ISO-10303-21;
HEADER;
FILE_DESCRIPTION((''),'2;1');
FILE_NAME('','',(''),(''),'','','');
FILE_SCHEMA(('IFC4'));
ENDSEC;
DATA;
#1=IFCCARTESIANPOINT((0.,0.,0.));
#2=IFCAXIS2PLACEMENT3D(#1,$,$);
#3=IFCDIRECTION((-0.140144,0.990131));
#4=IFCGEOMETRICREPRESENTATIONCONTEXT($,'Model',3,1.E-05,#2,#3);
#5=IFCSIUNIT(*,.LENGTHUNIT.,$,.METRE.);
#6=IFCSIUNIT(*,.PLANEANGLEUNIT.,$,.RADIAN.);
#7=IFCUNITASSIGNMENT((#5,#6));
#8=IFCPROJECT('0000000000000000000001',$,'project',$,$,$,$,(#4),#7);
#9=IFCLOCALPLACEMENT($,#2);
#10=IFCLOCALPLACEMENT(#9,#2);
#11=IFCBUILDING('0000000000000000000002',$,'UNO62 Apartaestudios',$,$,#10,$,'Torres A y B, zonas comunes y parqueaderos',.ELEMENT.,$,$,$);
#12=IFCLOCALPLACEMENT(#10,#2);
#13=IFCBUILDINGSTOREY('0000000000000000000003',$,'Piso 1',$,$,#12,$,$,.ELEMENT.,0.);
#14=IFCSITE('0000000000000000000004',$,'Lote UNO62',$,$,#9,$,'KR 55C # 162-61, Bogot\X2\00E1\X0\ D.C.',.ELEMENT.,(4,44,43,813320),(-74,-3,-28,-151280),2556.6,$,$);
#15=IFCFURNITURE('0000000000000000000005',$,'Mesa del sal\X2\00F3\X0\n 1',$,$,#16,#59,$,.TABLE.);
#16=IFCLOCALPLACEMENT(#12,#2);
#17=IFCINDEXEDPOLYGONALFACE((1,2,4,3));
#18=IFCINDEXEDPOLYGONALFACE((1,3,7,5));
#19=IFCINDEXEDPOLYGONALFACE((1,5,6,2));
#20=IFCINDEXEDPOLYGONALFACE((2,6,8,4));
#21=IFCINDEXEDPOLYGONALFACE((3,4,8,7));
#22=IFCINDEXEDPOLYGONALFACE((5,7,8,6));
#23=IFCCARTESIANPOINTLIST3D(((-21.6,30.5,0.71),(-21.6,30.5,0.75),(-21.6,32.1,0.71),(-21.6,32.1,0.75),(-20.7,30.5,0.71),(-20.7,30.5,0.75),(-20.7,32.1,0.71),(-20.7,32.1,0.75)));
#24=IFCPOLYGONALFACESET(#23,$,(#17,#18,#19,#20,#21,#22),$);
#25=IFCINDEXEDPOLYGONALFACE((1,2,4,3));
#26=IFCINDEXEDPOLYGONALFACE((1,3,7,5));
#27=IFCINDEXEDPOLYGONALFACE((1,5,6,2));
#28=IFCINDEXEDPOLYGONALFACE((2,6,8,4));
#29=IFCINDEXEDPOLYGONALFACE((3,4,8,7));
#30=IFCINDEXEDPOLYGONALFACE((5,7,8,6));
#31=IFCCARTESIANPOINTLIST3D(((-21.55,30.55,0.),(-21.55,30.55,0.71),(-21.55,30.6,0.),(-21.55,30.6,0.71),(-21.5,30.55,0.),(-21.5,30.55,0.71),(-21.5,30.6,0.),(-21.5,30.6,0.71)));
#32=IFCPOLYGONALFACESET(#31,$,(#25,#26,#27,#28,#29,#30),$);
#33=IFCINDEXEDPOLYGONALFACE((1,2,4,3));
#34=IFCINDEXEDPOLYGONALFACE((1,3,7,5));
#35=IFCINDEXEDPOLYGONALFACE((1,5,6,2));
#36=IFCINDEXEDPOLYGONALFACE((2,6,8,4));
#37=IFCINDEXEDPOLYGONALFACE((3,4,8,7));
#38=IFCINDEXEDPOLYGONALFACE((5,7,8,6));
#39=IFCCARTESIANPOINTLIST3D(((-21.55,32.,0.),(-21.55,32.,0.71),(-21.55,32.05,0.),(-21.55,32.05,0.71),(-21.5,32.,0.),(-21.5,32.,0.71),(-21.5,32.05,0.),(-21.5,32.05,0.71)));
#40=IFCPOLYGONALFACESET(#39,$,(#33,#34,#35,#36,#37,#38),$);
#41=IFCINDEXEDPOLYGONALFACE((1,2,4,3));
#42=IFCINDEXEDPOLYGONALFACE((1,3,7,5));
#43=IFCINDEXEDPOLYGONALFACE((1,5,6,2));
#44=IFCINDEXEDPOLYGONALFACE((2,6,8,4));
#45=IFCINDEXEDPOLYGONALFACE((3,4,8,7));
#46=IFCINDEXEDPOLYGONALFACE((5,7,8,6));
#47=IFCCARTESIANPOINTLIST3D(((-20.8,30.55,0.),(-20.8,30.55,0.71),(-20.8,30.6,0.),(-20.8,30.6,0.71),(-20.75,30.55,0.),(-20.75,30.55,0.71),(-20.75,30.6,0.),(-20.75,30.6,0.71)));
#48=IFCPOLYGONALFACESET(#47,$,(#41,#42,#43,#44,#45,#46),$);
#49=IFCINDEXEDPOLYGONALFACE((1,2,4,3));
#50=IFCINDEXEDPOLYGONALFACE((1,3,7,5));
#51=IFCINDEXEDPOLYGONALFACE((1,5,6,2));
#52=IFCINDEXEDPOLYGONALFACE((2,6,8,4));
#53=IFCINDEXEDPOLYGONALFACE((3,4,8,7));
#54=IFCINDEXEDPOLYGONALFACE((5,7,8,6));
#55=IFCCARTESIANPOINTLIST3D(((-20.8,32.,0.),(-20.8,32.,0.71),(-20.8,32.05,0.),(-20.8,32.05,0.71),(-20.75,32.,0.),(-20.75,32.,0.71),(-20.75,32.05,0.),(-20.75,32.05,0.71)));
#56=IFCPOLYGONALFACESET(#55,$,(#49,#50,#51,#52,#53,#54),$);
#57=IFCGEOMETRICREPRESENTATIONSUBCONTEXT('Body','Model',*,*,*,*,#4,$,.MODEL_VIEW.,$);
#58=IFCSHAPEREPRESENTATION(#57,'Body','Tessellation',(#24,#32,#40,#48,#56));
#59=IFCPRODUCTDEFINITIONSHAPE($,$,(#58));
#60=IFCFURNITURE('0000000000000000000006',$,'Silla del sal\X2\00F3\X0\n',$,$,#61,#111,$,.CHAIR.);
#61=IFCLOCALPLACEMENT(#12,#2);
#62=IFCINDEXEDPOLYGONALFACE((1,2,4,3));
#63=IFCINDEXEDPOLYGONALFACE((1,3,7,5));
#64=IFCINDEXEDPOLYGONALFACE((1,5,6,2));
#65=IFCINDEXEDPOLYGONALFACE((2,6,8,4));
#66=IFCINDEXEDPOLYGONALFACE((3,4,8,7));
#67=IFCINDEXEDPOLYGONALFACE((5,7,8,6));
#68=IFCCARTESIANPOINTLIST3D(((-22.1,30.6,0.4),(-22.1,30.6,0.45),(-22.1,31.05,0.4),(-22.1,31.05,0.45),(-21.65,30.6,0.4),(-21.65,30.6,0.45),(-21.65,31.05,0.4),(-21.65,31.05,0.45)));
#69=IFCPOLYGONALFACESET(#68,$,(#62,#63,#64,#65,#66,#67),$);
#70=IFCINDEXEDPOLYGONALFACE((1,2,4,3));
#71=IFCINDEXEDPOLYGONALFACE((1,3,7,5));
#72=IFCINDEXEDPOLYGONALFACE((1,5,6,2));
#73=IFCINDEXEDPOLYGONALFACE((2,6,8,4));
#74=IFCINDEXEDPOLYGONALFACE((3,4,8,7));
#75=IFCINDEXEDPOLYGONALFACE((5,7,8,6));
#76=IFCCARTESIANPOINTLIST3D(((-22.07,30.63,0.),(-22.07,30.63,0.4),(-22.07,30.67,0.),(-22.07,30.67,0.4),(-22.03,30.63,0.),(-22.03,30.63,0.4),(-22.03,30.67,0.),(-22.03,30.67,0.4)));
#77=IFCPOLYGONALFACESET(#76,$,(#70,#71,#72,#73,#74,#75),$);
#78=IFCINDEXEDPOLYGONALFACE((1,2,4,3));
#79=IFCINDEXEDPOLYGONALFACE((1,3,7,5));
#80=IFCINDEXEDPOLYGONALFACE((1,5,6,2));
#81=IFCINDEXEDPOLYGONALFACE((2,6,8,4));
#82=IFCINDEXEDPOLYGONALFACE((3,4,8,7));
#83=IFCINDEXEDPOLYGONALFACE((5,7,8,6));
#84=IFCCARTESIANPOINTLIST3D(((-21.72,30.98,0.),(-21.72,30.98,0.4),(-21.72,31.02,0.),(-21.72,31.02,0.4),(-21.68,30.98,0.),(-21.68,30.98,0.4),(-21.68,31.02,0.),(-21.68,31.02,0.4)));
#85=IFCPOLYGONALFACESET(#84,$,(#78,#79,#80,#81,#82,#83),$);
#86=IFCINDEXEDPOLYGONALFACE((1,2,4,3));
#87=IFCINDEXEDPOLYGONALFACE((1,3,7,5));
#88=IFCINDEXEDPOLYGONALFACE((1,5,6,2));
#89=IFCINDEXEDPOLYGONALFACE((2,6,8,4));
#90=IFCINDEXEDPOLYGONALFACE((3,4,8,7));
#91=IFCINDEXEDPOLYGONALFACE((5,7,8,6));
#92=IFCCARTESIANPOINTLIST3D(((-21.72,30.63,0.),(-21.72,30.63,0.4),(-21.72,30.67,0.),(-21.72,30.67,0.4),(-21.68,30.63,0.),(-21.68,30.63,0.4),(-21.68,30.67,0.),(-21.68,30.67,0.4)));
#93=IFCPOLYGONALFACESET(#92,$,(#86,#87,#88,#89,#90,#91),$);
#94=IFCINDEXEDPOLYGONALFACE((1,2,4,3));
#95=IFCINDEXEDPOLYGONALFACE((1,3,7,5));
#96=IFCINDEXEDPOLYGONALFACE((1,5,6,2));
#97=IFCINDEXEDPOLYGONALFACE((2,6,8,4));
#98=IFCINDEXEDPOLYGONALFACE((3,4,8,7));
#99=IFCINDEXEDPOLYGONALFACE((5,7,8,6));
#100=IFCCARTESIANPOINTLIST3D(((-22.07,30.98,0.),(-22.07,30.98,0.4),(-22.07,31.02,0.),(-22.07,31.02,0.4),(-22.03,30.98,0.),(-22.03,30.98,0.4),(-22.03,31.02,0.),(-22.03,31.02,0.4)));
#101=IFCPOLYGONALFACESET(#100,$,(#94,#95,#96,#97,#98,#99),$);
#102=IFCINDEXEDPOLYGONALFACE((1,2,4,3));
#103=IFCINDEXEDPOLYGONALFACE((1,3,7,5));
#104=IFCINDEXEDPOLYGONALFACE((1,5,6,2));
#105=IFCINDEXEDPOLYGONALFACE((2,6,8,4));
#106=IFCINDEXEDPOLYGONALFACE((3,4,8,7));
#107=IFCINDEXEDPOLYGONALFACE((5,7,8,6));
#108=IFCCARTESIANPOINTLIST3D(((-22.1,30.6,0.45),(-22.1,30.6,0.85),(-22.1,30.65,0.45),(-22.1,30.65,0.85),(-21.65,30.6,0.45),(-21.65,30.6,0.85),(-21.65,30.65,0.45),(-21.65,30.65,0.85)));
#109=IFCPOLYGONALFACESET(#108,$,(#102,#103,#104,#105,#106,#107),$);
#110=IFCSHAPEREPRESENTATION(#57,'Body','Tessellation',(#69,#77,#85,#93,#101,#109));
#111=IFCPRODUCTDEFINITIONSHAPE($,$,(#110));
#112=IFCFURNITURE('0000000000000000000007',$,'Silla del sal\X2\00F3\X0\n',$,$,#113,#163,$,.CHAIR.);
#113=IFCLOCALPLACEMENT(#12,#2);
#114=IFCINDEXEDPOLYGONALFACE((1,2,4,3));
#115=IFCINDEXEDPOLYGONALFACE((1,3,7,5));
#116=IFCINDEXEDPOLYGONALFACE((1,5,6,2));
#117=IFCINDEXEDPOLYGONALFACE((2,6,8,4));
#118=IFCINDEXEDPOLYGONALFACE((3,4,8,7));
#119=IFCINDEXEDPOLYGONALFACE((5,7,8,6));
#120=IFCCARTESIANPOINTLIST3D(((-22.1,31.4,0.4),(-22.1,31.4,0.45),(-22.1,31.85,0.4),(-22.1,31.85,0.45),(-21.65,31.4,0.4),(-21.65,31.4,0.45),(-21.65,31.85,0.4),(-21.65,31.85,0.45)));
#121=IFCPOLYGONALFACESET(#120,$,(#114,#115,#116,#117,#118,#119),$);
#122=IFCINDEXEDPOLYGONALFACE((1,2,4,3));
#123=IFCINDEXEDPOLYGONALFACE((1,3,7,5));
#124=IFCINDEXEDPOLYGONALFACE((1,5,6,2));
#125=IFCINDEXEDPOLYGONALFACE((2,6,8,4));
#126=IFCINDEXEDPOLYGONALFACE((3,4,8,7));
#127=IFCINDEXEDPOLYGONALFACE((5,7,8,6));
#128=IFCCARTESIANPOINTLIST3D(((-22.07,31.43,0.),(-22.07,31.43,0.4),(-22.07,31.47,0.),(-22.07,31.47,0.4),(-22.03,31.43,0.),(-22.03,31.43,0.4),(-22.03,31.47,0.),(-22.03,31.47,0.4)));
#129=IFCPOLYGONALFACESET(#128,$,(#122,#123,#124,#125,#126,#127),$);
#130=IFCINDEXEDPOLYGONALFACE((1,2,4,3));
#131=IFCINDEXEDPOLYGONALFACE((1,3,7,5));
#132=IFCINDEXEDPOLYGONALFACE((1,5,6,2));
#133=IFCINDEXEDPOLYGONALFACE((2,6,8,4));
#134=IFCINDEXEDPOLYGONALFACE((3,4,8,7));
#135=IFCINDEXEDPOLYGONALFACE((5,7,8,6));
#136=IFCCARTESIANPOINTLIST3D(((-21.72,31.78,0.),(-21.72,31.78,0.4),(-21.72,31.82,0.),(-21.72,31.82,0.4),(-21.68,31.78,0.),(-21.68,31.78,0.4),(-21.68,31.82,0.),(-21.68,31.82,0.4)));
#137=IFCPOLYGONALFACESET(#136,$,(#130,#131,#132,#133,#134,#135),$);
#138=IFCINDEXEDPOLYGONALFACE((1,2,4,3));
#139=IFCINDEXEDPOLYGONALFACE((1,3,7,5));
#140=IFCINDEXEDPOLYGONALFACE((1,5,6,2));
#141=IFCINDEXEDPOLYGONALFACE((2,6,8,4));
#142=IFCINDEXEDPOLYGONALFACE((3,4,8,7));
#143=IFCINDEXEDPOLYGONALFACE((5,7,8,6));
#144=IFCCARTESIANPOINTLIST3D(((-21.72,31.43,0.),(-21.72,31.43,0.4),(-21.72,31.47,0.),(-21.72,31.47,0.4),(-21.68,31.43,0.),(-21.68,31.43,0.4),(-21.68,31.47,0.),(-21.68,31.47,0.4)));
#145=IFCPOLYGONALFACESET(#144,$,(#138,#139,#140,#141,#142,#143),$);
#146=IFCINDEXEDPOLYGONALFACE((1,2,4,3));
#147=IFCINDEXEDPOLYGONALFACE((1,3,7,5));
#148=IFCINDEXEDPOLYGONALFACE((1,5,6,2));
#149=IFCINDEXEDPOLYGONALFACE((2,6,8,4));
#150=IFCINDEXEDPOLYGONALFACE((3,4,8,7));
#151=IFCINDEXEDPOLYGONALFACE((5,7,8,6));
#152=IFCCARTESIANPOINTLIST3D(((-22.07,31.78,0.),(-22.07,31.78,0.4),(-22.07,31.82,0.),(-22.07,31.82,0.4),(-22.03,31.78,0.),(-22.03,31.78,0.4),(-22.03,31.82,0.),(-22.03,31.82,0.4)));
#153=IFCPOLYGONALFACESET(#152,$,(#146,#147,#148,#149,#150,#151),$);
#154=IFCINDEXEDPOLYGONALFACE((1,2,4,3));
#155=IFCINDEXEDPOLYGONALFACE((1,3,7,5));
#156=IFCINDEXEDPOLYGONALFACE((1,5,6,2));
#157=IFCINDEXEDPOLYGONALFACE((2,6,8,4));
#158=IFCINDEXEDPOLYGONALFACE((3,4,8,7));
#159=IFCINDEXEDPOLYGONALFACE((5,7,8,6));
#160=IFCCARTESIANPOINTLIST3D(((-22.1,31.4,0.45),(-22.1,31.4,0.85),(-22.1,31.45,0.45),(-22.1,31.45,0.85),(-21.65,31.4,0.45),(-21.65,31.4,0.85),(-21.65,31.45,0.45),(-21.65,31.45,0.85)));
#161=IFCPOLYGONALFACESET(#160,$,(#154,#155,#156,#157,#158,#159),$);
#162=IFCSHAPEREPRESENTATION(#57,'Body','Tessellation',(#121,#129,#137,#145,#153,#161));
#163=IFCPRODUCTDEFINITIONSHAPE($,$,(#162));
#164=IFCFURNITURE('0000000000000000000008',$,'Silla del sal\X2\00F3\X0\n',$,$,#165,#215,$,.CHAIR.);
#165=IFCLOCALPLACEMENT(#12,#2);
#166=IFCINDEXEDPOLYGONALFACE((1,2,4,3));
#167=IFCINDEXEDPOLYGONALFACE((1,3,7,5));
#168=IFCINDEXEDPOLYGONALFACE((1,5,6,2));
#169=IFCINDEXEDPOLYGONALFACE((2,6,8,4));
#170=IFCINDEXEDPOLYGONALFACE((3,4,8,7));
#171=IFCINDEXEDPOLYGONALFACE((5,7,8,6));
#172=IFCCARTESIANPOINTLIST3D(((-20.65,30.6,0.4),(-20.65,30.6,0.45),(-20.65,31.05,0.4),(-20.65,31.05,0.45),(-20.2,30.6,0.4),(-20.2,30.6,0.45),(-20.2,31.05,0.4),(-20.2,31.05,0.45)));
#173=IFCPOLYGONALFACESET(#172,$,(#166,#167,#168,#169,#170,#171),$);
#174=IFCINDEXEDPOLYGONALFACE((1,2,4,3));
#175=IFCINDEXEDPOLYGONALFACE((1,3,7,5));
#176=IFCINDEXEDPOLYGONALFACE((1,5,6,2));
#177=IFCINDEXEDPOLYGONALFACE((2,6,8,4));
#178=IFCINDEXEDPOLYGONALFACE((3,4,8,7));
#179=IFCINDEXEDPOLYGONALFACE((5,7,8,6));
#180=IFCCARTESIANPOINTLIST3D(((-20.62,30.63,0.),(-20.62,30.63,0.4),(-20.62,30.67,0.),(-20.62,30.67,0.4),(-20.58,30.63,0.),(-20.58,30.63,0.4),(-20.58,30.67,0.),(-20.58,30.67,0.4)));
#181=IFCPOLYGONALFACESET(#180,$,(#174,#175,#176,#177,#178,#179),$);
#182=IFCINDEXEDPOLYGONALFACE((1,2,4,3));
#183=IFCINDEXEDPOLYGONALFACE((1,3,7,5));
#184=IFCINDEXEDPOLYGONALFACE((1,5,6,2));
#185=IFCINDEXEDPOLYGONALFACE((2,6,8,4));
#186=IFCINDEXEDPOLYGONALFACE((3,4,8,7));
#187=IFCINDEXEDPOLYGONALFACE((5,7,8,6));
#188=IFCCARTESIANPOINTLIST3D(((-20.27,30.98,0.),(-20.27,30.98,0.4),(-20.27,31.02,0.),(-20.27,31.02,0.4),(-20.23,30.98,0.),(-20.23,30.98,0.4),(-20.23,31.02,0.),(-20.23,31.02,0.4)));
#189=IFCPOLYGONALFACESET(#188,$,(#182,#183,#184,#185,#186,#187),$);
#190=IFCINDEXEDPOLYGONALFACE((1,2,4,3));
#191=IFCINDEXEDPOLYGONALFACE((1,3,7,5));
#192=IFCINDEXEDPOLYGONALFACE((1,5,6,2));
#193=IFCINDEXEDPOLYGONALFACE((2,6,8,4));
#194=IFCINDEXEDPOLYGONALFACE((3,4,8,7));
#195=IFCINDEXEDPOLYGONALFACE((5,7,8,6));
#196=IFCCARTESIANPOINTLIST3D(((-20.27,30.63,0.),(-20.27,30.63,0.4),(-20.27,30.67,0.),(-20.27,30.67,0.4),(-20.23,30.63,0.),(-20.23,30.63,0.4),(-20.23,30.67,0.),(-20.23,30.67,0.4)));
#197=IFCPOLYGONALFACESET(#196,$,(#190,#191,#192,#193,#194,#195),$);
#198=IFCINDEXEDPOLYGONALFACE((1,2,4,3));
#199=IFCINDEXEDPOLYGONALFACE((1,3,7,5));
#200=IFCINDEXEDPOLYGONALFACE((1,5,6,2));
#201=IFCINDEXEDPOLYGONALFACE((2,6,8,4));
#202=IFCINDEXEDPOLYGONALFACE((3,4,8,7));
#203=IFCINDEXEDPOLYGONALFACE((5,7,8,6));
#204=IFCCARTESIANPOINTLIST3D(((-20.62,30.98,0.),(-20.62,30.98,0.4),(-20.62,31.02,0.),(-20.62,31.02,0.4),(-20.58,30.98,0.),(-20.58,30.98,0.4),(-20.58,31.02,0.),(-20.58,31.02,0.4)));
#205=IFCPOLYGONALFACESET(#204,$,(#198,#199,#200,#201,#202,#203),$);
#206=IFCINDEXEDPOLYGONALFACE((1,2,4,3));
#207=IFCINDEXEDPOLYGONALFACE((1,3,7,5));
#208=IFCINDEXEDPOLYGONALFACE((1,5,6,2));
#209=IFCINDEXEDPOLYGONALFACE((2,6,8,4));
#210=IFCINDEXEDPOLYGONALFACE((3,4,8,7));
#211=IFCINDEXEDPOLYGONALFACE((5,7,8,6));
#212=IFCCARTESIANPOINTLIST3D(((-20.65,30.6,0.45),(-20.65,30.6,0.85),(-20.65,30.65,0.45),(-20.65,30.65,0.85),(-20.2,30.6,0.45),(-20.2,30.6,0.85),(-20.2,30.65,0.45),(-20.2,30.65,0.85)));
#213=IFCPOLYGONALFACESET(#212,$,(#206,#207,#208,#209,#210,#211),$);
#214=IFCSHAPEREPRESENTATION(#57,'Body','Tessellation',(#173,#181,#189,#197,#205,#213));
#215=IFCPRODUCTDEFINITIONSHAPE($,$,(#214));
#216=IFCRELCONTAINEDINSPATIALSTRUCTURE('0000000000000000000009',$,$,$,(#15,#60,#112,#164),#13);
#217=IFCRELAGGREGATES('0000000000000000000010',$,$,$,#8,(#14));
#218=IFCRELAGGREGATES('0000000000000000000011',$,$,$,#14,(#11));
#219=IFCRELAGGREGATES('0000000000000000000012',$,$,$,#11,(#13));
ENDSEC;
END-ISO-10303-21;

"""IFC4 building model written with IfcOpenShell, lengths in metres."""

from ifc_helpers import new_model, si_unit, direction, frame, frame_2d, origin, place, context, subcontext, project, spatial, rectangle, extrude, element, save


model = new_model("IFC4")

# Units and contexts
model_context = context("Model", 3, precision=1e-05, world=origin(), true_north=direction((-0.140144, 0.990131)))
body_context = subcontext(model_context, "Body", "Model", "MODEL_VIEW")
ifc_project = project(units=[si_unit("LENGTHUNIT", "METRE"), si_unit("PLANEANGLEUNIT", "RADIAN")], contexts=[model_context])

# Site, building, storey
site_placement = place(None, origin())
site = spatial("IfcSite", under=ifc_project, at=site_placement, Name="Lote UNO62", LongName="KR 55C # 162-61, Bogotá D.C.", CompositionType="ELEMENT", RefLatitude=(4, 44, 43, 813320), RefLongitude=(-74, -3, -28, -151280), RefElevation=2556.6)
building_placement = place(site_placement, origin())
building = spatial("IfcBuilding", under=site, at=building_placement, Name="UNO62 Apartaestudios", LongName="Torres A y B, zonas comunes y parqueaderos", CompositionType="ELEMENT")
storey_placement = place(building_placement, origin())
storey = spatial("IfcBuildingStorey", under=building, at=storey_placement, Name="Piso 1", CompositionType="ELEMENT", Elevation=0.0)

# Furniture
furniture_1_placement = place(storey_placement, origin())
element("IfcFurniture", 1, at=furniture_1_placement, inside=storey, Name="Mesa del salón 1", PredefinedType="TABLE", context=body_context, shape_type="SweptSolid", body=[
    extrude(rectangle(XDim=0.9, YDim=1.6, at=frame_2d((-21.15, 31.3))), frame((0.0, 0.0, 0.71)), (0.0, 0.0, 1.0), 0.04),
    extrude(rectangle(XDim=0.05, YDim=0.05, at=frame_2d((-21.525, 30.575))), origin(), (0.0, 0.0, 1.0), 0.71),
    extrude(rectangle(XDim=0.05, YDim=0.05, at=frame_2d((-21.525, 32.025))), origin(), (0.0, 0.0, 1.0), 0.71),
    extrude(rectangle(XDim=0.05, YDim=0.05, at=frame_2d((-20.775, 30.575))), origin(), (0.0, 0.0, 1.0), 0.71),
    extrude(rectangle(XDim=0.05, YDim=0.05, at=frame_2d((-20.775, 32.025))), origin(), (0.0, 0.0, 1.0), 0.71),
])
furniture_2_placement = place(storey_placement, origin())
element("IfcFurniture", 2, at=furniture_2_placement, inside=storey, Name="Silla del salón", PredefinedType="CHAIR", context=body_context, shape_type="SweptSolid", body=[
    extrude(rectangle(XDim=0.45, YDim=0.45, at=frame_2d((-21.875, 30.825))), frame((0.0, 0.0, 0.4)), (0.0, 0.0, 1.0), 0.05),
    extrude(rectangle(XDim=0.04, YDim=0.04, at=frame_2d((-22.05, 30.65))), origin(), (0.0, 0.0, 1.0), 0.4),
    extrude(rectangle(XDim=0.04, YDim=0.04, at=frame_2d((-21.7, 31.0))), origin(), (0.0, 0.0, 1.0), 0.4),
    extrude(rectangle(XDim=0.04, YDim=0.04, at=frame_2d((-21.7, 30.65))), origin(), (0.0, 0.0, 1.0), 0.4),
    extrude(rectangle(XDim=0.04, YDim=0.04, at=frame_2d((-22.05, 31.0))), origin(), (0.0, 0.0, 1.0), 0.4),
    extrude(rectangle(XDim=0.45, YDim=0.05, at=frame_2d((-21.875, 30.625))), frame((0.0, 0.0, 0.45)), (0.0, 0.0, 1.0), 0.4),
])
furniture_3_placement = place(storey_placement, origin())
element("IfcFurniture", 3, at=furniture_3_placement, inside=storey, Name="Silla del salón", PredefinedType="CHAIR", context=body_context, shape_type="SweptSolid", body=[
    extrude(rectangle(XDim=0.45, YDim=0.45, at=frame_2d((-21.875, 31.625))), frame((0.0, 0.0, 0.4)), (0.0, 0.0, 1.0), 0.05),
    extrude(rectangle(XDim=0.04, YDim=0.04, at=frame_2d((-22.05, 31.45))), origin(), (0.0, 0.0, 1.0), 0.4),
    extrude(rectangle(XDim=0.04, YDim=0.04, at=frame_2d((-21.7, 31.8))), origin(), (0.0, 0.0, 1.0), 0.4),
    extrude(rectangle(XDim=0.04, YDim=0.04, at=frame_2d((-21.7, 31.45))), origin(), (0.0, 0.0, 1.0), 0.4),
    extrude(rectangle(XDim=0.04, YDim=0.04, at=frame_2d((-22.05, 31.8))), origin(), (0.0, 0.0, 1.0), 0.4),
    extrude(rectangle(XDim=0.45, YDim=0.05, at=frame_2d((-21.875, 31.425))), frame((0.0, 0.0, 0.45)), (0.0, 0.0, 1.0), 0.4),
])
furniture_4_placement = place(storey_placement, origin())
element("IfcFurniture", 4, at=furniture_4_placement, inside=storey, Name="Silla del salón", PredefinedType="CHAIR", context=body_context, shape_type="SweptSolid", body=[
    extrude(rectangle(XDim=0.45, YDim=0.45, at=frame_2d((-20.425, 30.825))), frame((0.0, 0.0, 0.4)), (0.0, 0.0, 1.0), 0.05),
    extrude(rectangle(XDim=0.04, YDim=0.04, at=frame_2d((-20.6, 30.65))), origin(), (0.0, 0.0, 1.0), 0.4),
    extrude(rectangle(XDim=0.04, YDim=0.04, at=frame_2d((-20.25, 31.0))), origin(), (0.0, 0.0, 1.0), 0.4),
    extrude(rectangle(XDim=0.04, YDim=0.04, at=frame_2d((-20.25, 30.65))), origin(), (0.0, 0.0, 1.0), 0.4),
    extrude(rectangle(XDim=0.04, YDim=0.04, at=frame_2d((-20.6, 31.0))), origin(), (0.0, 0.0, 1.0), 0.4),
    extrude(rectangle(XDim=0.45, YDim=0.05, at=frame_2d((-20.425, 30.625))), frame((0.0, 0.0, 0.45)), (0.0, 0.0, 1.0), 0.4),
])

save(model, "model.ifc")
